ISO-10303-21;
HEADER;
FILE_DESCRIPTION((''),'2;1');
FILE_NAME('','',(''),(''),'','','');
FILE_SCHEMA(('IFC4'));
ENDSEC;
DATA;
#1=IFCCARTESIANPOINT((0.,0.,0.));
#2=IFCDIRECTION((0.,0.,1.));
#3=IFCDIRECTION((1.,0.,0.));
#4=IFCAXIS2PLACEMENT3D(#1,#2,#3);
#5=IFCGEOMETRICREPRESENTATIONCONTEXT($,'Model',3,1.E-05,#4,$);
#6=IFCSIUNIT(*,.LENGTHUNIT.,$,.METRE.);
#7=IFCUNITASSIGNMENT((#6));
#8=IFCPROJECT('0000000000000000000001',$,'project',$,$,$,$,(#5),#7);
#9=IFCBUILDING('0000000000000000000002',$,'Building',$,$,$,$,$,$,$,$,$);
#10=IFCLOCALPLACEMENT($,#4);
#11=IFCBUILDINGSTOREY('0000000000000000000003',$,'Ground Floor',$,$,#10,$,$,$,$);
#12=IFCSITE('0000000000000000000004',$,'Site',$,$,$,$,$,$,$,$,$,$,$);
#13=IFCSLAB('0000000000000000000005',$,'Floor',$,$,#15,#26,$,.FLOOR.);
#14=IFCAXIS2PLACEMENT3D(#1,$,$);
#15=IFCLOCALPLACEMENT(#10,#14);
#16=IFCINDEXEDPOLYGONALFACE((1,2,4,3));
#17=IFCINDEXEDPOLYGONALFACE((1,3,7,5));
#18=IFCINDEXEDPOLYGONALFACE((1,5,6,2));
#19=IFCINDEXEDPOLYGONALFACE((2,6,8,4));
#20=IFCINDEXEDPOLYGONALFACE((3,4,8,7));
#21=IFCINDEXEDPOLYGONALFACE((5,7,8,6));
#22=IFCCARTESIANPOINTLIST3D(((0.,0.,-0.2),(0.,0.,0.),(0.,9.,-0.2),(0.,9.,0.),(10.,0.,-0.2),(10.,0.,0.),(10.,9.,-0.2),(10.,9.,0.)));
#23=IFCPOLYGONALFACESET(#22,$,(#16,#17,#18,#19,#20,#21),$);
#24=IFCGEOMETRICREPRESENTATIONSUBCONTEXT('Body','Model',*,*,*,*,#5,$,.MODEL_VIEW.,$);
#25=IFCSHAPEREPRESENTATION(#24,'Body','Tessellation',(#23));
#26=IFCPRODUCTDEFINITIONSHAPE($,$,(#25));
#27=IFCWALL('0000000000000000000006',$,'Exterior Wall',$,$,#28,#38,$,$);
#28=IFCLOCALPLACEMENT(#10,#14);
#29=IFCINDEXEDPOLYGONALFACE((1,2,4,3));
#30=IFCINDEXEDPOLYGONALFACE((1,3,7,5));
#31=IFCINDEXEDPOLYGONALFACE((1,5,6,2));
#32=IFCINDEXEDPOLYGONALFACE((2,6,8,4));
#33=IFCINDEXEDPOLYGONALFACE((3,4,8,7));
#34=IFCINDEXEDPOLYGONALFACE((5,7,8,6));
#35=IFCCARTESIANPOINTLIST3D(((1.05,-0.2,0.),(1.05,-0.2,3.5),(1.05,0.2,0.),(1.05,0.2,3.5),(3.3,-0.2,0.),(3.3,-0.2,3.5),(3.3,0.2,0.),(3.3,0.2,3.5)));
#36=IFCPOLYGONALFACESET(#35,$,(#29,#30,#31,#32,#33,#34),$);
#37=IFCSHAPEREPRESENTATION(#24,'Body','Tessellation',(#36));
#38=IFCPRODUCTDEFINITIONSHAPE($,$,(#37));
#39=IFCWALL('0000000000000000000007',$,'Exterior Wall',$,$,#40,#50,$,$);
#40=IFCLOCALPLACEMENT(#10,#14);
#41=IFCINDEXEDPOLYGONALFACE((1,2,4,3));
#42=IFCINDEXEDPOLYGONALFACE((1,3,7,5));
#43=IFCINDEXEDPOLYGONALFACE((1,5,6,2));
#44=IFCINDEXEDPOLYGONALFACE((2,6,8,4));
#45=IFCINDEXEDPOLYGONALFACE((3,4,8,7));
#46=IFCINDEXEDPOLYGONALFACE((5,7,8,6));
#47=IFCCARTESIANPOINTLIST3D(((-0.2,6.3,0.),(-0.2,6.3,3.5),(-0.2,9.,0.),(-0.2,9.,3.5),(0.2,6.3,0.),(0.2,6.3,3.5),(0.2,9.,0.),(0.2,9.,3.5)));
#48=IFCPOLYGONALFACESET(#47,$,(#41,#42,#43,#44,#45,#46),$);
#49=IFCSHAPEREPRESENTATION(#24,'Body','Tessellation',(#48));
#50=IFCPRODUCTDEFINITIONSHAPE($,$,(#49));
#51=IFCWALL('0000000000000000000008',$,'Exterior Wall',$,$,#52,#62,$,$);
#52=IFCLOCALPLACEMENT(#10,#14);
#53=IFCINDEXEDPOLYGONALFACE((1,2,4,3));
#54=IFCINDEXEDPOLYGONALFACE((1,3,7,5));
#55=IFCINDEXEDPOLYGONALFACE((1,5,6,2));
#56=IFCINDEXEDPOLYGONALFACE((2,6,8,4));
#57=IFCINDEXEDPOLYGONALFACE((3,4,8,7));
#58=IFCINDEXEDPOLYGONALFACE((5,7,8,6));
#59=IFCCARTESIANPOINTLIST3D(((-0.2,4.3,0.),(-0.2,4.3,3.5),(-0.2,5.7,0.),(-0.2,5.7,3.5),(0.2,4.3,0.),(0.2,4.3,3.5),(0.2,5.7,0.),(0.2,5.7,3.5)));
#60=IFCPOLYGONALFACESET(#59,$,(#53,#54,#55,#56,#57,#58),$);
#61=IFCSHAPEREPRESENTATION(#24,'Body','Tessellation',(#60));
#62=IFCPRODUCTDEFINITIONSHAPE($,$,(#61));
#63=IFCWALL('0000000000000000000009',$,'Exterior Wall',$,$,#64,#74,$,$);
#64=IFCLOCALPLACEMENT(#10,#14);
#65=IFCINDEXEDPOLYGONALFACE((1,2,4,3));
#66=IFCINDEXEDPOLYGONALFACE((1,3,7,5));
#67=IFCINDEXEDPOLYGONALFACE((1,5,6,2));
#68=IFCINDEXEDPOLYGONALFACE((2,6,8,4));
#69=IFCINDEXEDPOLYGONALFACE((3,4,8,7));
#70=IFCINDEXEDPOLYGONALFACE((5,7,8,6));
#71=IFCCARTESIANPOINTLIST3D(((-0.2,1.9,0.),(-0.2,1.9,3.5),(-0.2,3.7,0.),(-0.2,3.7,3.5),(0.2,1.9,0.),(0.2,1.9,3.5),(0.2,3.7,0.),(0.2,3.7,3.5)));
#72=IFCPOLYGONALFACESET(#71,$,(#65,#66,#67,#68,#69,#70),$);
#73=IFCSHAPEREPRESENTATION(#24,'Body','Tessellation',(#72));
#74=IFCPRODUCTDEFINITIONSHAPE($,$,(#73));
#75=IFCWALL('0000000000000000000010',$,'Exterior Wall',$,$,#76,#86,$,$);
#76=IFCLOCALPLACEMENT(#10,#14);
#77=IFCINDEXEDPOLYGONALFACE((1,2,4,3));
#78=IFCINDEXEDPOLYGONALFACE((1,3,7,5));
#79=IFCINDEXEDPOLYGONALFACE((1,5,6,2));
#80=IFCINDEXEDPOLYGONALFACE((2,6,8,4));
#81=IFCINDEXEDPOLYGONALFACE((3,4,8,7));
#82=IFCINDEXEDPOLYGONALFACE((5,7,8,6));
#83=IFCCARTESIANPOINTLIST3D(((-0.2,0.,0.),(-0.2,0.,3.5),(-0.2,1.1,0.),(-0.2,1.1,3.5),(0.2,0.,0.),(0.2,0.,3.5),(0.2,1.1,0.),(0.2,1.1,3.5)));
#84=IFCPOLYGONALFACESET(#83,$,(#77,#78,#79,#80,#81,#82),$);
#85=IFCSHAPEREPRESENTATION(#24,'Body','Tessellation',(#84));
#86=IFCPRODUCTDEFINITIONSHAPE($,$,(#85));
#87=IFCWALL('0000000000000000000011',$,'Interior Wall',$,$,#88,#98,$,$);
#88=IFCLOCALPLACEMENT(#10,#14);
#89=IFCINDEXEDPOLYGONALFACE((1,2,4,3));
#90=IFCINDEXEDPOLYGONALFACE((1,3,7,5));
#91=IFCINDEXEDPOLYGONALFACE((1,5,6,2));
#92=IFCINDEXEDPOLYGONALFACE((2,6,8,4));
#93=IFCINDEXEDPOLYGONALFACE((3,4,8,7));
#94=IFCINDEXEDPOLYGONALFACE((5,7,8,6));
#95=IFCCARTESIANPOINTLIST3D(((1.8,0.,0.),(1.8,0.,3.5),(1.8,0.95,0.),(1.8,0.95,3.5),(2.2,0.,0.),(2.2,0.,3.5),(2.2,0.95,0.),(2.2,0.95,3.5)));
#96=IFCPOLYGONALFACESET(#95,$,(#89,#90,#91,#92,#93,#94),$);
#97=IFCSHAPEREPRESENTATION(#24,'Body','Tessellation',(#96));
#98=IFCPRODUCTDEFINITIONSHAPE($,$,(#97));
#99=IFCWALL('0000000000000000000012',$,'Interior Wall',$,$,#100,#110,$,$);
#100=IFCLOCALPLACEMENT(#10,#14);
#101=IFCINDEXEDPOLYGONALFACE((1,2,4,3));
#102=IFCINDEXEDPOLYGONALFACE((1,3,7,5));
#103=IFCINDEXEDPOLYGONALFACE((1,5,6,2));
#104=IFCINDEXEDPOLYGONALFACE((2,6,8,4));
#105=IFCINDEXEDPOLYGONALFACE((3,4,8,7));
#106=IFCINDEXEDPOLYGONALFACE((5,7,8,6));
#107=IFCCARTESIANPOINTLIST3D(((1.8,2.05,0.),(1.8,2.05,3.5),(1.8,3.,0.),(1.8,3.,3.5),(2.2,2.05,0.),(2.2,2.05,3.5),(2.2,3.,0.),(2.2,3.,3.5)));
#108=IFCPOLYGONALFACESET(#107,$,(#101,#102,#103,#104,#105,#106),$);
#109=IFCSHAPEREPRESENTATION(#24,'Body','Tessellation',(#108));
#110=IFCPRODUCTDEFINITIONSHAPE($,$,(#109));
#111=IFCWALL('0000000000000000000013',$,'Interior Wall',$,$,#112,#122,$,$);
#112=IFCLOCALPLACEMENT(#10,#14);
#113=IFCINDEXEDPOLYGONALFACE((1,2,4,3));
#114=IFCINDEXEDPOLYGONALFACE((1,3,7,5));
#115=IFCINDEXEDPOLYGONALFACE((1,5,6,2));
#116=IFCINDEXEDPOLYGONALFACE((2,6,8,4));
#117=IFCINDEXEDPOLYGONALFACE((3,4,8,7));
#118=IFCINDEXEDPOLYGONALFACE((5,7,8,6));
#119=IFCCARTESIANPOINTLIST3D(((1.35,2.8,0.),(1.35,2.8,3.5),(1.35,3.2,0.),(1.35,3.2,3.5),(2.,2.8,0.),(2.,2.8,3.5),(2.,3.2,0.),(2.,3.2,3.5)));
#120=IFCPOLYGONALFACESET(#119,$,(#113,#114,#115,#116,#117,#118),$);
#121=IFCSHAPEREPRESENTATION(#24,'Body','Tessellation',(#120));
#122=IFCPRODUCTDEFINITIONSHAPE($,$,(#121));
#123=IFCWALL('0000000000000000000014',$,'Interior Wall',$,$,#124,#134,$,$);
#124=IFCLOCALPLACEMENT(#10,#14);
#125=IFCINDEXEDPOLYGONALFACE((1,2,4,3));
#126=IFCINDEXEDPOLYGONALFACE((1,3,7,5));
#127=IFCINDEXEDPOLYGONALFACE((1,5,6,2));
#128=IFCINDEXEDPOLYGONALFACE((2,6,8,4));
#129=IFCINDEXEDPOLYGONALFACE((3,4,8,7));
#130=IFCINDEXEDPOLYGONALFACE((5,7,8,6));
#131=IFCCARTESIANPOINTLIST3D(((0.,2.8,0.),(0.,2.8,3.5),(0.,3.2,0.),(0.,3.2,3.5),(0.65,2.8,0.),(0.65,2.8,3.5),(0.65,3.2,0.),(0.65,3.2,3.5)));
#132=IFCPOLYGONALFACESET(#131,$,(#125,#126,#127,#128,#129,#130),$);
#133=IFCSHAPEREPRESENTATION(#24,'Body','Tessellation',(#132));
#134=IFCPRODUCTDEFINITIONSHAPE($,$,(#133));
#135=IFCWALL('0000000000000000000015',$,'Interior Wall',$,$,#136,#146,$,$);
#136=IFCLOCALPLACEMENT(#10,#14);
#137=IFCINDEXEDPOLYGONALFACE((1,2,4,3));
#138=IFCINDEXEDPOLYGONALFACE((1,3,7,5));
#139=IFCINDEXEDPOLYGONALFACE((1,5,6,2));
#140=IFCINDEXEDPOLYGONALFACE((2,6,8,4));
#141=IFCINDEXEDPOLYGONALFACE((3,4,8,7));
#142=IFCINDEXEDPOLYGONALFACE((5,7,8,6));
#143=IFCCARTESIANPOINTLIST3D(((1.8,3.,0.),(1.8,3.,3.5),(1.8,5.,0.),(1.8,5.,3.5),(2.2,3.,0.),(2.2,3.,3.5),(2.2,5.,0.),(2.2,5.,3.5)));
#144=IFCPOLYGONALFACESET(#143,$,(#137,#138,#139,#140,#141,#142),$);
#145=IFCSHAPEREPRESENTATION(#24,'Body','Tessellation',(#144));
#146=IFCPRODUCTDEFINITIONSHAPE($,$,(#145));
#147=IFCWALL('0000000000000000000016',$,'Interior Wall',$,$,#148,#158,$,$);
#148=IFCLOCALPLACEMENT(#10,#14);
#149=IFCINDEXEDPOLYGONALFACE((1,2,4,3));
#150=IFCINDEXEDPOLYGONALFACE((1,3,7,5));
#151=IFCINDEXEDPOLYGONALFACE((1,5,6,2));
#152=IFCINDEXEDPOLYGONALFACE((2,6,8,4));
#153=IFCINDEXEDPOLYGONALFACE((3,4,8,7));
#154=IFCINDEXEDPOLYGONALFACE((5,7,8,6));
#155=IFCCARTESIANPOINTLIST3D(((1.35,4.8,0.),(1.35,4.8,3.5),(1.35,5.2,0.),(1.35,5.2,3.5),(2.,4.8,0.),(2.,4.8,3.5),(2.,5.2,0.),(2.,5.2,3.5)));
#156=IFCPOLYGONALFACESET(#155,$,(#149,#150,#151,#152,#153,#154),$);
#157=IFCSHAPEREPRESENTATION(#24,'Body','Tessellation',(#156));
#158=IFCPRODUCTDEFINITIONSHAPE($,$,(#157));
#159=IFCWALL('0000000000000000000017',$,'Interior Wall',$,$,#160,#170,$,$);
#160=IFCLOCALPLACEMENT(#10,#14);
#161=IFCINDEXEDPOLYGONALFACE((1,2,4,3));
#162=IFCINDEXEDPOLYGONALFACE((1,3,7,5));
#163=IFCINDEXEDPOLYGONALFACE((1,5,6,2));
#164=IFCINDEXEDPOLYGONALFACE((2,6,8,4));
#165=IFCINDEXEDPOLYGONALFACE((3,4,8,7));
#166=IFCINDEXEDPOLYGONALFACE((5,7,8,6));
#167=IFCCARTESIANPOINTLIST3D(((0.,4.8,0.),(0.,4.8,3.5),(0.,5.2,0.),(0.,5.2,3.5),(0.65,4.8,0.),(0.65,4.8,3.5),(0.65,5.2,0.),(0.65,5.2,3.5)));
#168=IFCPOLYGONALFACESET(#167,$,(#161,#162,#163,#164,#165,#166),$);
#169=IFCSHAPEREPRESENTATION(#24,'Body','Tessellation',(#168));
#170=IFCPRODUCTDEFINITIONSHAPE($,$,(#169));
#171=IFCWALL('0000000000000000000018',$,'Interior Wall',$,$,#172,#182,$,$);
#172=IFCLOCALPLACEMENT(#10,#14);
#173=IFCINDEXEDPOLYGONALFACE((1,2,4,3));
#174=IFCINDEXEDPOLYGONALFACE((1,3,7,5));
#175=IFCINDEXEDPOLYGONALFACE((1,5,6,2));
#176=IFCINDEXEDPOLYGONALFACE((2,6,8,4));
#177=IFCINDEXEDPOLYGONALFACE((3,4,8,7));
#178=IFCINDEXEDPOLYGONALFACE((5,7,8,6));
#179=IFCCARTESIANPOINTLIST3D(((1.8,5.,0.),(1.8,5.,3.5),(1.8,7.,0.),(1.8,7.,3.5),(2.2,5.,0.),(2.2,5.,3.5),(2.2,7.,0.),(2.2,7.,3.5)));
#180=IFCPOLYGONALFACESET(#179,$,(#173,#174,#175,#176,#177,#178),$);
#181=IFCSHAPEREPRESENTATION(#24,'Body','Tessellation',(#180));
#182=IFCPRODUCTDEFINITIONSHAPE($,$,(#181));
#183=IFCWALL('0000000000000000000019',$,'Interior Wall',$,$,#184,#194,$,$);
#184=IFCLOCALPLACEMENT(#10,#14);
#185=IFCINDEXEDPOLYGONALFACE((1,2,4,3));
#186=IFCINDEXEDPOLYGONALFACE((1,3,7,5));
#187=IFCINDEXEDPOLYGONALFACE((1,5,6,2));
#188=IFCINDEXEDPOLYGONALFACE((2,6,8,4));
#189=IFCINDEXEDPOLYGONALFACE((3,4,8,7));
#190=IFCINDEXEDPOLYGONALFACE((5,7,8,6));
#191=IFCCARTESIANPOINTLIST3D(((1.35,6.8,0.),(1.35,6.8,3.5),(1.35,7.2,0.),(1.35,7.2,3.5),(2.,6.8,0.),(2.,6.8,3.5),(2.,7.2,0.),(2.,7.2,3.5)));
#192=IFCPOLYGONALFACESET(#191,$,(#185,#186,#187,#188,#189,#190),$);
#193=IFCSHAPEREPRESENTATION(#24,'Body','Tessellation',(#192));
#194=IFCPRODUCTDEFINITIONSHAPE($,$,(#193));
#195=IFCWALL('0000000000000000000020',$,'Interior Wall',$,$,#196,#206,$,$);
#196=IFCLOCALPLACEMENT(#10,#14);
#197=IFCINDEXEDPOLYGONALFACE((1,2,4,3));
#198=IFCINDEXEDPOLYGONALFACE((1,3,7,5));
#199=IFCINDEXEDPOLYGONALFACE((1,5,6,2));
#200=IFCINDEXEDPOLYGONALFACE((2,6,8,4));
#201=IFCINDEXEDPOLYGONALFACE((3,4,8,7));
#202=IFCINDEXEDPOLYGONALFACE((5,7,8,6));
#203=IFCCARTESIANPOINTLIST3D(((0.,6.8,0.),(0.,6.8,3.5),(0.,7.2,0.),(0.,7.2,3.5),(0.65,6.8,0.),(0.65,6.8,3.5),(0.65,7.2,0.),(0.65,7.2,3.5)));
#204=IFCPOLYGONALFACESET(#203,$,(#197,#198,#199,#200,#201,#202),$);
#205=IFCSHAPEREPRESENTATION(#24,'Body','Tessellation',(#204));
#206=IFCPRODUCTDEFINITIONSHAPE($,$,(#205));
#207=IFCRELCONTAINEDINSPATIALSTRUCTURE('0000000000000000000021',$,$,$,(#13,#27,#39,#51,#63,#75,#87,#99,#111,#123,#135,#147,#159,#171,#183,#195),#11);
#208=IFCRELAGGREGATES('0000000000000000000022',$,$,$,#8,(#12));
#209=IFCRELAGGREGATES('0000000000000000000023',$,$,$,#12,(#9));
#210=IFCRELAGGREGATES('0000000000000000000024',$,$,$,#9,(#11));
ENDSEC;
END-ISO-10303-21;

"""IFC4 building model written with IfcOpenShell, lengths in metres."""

from ifc_helpers import new_model, si_unit, frame, origin_with_axes, place, context, subcontext, project, spatial, indexed_curve, outline, extrude, element, save


model = new_model("IFC4")

# Units and contexts
model_context = context("Model", 3, precision=1e-05, world=origin_with_axes())
body_context = subcontext(model_context, "Body", "Model", "MODEL_VIEW")
ifc_project = project(units=[si_unit("LENGTHUNIT", "METRE")], contexts=[model_context])

# Site, building, storey
site = spatial("IfcSite", under=ifc_project, Name="Site")
building = spatial("IfcBuilding", under=site, Name="Building")
storey_placement = place(None, origin_with_axes())
storey = spatial("IfcBuildingStorey", under=building, at=storey_placement, Name="Ground Floor")

# Slab
slab_placement = place(storey_placement, frame((0.0, 0.0, -0.2), z_axis=(0.0, 0.0, 1.0), x_axis=(1.0, 0.0, 0.0)))
element("IfcSlab", 1, at=slab_placement, inside=storey, Name="Floor", PredefinedType="FLOOR", context=body_context, shape_type="SweptSolid", body=[
    extrude(outline(indexed_curve([(0.0, 0.0), (10.0, 0.0), (10.0, 9.0), (0.0, 9.0)])), None, (0.0, 0.0, 1.0), 0.2),
])

# Walls
wall_1_placement = place(storey_placement, frame((1.05, 0.0, 0.0), z_axis=(0.0, 0.0, 1.0), x_axis=(1.0, 0.0, 0.0)))
element("IfcWall", 2, at=wall_1_placement, inside=storey, Name="Exterior Wall", context=body_context, shape_type="SweptSolid", body=[
    extrude(outline(indexed_curve([(0.0, 0.0), (0.0, 0.4), (2.25, 0.4), (2.25, 0.0), (0.0, 0.0)], self_intersect=False)), frame((0.0, -0.2, 0.0), z_axis=(0.0, 0.0, 1.0), x_axis=(1.0, 0.0, 0.0)), (0.0, 0.0, 1.0), 3.5),
])
wall_2_placement = place(storey_placement, frame((0.0, 9.0, 0.0), z_axis=(0.0, 0.0, 1.0), x_axis=(0.0, -1.0, 0.0)))
element("IfcWall", 3, at=wall_2_placement, inside=storey, Name="Exterior Wall", context=body_context, shape_type="SweptSolid", body=[
    extrude(outline(indexed_curve([(0.0, 0.0), (0.0, 0.4), (2.7, 0.4), (2.7, 0.0), (0.0, 0.0)], self_intersect=False)), frame((0.0, -0.2, 0.0), z_axis=(0.0, 0.0, 1.0), x_axis=(1.0, 0.0, 0.0)), (0.0, 0.0, 1.0), 3.5),
])
wall_3_placement = place(storey_placement, frame((0.0, 5.7, 0.0), z_axis=(0.0, 0.0, 1.0), x_axis=(0.0, -1.0, 0.0)))
element("IfcWall", 4, at=wall_3_placement, inside=storey, Name="Exterior Wall", context=body_context, shape_type="SweptSolid", body=[
    extrude(outline(indexed_curve([(0.0, 0.0), (0.0, 0.4), (1.4, 0.4), (1.4, 0.0), (0.0, 0.0)], self_intersect=False)), frame((0.0, -0.2, 0.0), z_axis=(0.0, 0.0, 1.0), x_axis=(1.0, 0.0, 0.0)), (0.0, 0.0, 1.0), 3.5),
])
wall_4_placement = place(storey_placement, frame((0.0, 3.7, 0.0), z_axis=(0.0, 0.0, 1.0), x_axis=(0.0, -1.0, 0.0)))
element("IfcWall", 5, at=wall_4_placement, inside=storey, Name="Exterior Wall", context=body_context, shape_type="SweptSolid", body=[
    extrude(outline(indexed_curve([(0.0, 0.0), (0.0, 0.4), (1.8, 0.4), (1.8, 0.0), (0.0, 0.0)], self_intersect=False)), frame((0.0, -0.2, 0.0), z_axis=(0.0, 0.0, 1.0), x_axis=(1.0, 0.0, 0.0)), (0.0, 0.0, 1.0), 3.5),
])
wall_5_placement = place(storey_placement, frame((0.0, 1.1, 0.0), z_axis=(0.0, 0.0, 1.0), x_axis=(0.0, -1.0, 0.0)))
element("IfcWall", 6, at=wall_5_placement, inside=storey, Name="Exterior Wall", context=body_context, shape_type="SweptSolid", body=[
    extrude(outline(indexed_curve([(0.0, 0.0), (0.0, 0.4), (1.1, 0.4), (1.1, 0.0), (0.0, 0.0)], self_intersect=False)), frame((0.0, -0.2, 0.0), z_axis=(0.0, 0.0, 1.0), x_axis=(1.0, 0.0, 0.0)), (0.0, 0.0, 1.0), 3.5),
])
wall_6_placement = place(storey_placement, frame((2.0, 0.0, 0.0), z_axis=(0.0, 0.0, 1.0), x_axis=(0.0, 1.0, 0.0)))
element("IfcWall", 7, at=wall_6_placement, inside=storey, Name="Interior Wall", context=body_context, shape_type="SweptSolid", body=[
    extrude(outline(indexed_curve([(0.0, 0.0), (0.0, 0.4), (0.95, 0.4), (0.95, 0.0), (0.0, 0.0)], self_intersect=False)), frame((0.0, -0.2, 0.0), z_axis=(0.0, 0.0, 1.0), x_axis=(1.0, 0.0, 0.0)), (0.0, 0.0, 1.0), 3.5),
])
wall_7_placement = place(storey_placement, frame((2.0, 2.05, 0.0), z_axis=(0.0, 0.0, 1.0), x_axis=(0.0, 1.0, 0.0)))
element("IfcWall", 8, at=wall_7_placement, inside=storey, Name="Interior Wall", context=body_context, shape_type="SweptSolid", body=[
    extrude(outline(indexed_curve([(0.0, 0.0), (0.0, 0.4), (0.95, 0.4), (0.95, 0.0), (0.0, 0.0)], self_intersect=False)), frame((0.0, -0.2, 0.0), z_axis=(0.0, 0.0, 1.0), x_axis=(1.0, 0.0, 0.0)), (0.0, 0.0, 1.0), 3.5),
])
for number, where, z_axis, x_axis, name in (
    (9, (2.0, 3.0, 0.0), (0.0, 0.0, 1.0), (-1.0, 0.0, 0.0), "Interior Wall"),
    (10, (0.65, 3.0, 0.0), (0.0, 0.0, 1.0), (-1.0, 0.0, 0.0), "Interior Wall"),
):
    element("IfcWall", number, at=place(storey_placement, frame(where, z_axis=z_axis, x_axis=x_axis)), inside=storey, Name=name, context=body_context, shape_type="SweptSolid", body=[
        extrude(outline(indexed_curve([(0.0, 0.0), (0.0, 0.4), (0.65, 0.4), (0.65, 0.0), (0.0, 0.0)], self_intersect=False)), frame((0.0, -0.2, 0.0), z_axis=(0.0, 0.0, 1.0), x_axis=(1.0, 0.0, 0.0)), (0.0, 0.0, 1.0), 3.5),
    ])
wall_8_placement = place(storey_placement, frame((2.0, 5.0, 0.0), z_axis=(0.0, 0.0, 1.0), x_axis=(0.0, -1.0, 0.0)))
element("IfcWall", 11, at=wall_8_placement, inside=storey, Name="Interior Wall", context=body_context, shape_type="SweptSolid", body=[
    extrude(outline(indexed_curve([(0.0, 0.0), (0.0, 0.4), (2.0, 0.4), (2.0, 0.0), (0.0, 0.0)], self_intersect=False)), frame((0.0, -0.2, 0.0), z_axis=(0.0, 0.0, 1.0), x_axis=(1.0, 0.0, 0.0)), (0.0, 0.0, 1.0), 3.5),
])
for number, where, z_axis, x_axis, name in (
    (12, (2.0, 5.0, 0.0), (0.0, 0.0, 1.0), (-1.0, 0.0, 0.0), "Interior Wall"),
    (13, (0.65, 5.0, 0.0), (0.0, 0.0, 1.0), (-1.0, 0.0, 0.0), "Interior Wall"),
):
    element("IfcWall", number, at=place(storey_placement, frame(where, z_axis=z_axis, x_axis=x_axis)), inside=storey, Name=name, context=body_context, shape_type="SweptSolid", body=[
        extrude(outline(indexed_curve([(0.0, 0.0), (0.0, 0.4), (0.65, 0.4), (0.65, 0.0), (0.0, 0.0)], self_intersect=False)), frame((0.0, -0.2, 0.0), z_axis=(0.0, 0.0, 1.0), x_axis=(1.0, 0.0, 0.0)), (0.0, 0.0, 1.0), 3.5),
    ])
wall_9_placement = place(storey_placement, frame((2.0, 5.0, 0.0), z_axis=(0.0, 0.0, 1.0), x_axis=(0.0, 1.0, 0.0)))
element("IfcWall", 14, at=wall_9_placement, inside=storey, Name="Interior Wall", context=body_context, shape_type="SweptSolid", body=[
    extrude(outline(indexed_curve([(0.0, 0.0), (0.0, 0.4), (2.0, 0.4), (2.0, 0.0), (0.0, 0.0)], self_intersect=False)), frame((0.0, -0.2, 0.0), z_axis=(0.0, 0.0, 1.0), x_axis=(1.0, 0.0, 0.0)), (0.0, 0.0, 1.0), 3.5),
])
for number, where, z_axis, x_axis, name in (
    (15, (2.0, 7.0, 0.0), (0.0, 0.0, 1.0), (-1.0, 0.0, 0.0), "Interior Wall"),
    (16, (0.65, 7.0, 0.0), (0.0, 0.0, 1.0), (-1.0, 0.0, 0.0), "Interior Wall"),
):
    element("IfcWall", number, at=place(storey_placement, frame(where, z_axis=z_axis, x_axis=x_axis)), inside=storey, Name=name, context=body_context, shape_type="SweptSolid", body=[
        extrude(outline(indexed_curve([(0.0, 0.0), (0.0, 0.4), (0.65, 0.4), (0.65, 0.0), (0.0, 0.0)], self_intersect=False)), frame((0.0, -0.2, 0.0), z_axis=(0.0, 0.0, 1.0), x_axis=(1.0, 0.0, 0.0)), (0.0, 0.0, 1.0), 3.5),
    ])

save(model, "model.ifc")
